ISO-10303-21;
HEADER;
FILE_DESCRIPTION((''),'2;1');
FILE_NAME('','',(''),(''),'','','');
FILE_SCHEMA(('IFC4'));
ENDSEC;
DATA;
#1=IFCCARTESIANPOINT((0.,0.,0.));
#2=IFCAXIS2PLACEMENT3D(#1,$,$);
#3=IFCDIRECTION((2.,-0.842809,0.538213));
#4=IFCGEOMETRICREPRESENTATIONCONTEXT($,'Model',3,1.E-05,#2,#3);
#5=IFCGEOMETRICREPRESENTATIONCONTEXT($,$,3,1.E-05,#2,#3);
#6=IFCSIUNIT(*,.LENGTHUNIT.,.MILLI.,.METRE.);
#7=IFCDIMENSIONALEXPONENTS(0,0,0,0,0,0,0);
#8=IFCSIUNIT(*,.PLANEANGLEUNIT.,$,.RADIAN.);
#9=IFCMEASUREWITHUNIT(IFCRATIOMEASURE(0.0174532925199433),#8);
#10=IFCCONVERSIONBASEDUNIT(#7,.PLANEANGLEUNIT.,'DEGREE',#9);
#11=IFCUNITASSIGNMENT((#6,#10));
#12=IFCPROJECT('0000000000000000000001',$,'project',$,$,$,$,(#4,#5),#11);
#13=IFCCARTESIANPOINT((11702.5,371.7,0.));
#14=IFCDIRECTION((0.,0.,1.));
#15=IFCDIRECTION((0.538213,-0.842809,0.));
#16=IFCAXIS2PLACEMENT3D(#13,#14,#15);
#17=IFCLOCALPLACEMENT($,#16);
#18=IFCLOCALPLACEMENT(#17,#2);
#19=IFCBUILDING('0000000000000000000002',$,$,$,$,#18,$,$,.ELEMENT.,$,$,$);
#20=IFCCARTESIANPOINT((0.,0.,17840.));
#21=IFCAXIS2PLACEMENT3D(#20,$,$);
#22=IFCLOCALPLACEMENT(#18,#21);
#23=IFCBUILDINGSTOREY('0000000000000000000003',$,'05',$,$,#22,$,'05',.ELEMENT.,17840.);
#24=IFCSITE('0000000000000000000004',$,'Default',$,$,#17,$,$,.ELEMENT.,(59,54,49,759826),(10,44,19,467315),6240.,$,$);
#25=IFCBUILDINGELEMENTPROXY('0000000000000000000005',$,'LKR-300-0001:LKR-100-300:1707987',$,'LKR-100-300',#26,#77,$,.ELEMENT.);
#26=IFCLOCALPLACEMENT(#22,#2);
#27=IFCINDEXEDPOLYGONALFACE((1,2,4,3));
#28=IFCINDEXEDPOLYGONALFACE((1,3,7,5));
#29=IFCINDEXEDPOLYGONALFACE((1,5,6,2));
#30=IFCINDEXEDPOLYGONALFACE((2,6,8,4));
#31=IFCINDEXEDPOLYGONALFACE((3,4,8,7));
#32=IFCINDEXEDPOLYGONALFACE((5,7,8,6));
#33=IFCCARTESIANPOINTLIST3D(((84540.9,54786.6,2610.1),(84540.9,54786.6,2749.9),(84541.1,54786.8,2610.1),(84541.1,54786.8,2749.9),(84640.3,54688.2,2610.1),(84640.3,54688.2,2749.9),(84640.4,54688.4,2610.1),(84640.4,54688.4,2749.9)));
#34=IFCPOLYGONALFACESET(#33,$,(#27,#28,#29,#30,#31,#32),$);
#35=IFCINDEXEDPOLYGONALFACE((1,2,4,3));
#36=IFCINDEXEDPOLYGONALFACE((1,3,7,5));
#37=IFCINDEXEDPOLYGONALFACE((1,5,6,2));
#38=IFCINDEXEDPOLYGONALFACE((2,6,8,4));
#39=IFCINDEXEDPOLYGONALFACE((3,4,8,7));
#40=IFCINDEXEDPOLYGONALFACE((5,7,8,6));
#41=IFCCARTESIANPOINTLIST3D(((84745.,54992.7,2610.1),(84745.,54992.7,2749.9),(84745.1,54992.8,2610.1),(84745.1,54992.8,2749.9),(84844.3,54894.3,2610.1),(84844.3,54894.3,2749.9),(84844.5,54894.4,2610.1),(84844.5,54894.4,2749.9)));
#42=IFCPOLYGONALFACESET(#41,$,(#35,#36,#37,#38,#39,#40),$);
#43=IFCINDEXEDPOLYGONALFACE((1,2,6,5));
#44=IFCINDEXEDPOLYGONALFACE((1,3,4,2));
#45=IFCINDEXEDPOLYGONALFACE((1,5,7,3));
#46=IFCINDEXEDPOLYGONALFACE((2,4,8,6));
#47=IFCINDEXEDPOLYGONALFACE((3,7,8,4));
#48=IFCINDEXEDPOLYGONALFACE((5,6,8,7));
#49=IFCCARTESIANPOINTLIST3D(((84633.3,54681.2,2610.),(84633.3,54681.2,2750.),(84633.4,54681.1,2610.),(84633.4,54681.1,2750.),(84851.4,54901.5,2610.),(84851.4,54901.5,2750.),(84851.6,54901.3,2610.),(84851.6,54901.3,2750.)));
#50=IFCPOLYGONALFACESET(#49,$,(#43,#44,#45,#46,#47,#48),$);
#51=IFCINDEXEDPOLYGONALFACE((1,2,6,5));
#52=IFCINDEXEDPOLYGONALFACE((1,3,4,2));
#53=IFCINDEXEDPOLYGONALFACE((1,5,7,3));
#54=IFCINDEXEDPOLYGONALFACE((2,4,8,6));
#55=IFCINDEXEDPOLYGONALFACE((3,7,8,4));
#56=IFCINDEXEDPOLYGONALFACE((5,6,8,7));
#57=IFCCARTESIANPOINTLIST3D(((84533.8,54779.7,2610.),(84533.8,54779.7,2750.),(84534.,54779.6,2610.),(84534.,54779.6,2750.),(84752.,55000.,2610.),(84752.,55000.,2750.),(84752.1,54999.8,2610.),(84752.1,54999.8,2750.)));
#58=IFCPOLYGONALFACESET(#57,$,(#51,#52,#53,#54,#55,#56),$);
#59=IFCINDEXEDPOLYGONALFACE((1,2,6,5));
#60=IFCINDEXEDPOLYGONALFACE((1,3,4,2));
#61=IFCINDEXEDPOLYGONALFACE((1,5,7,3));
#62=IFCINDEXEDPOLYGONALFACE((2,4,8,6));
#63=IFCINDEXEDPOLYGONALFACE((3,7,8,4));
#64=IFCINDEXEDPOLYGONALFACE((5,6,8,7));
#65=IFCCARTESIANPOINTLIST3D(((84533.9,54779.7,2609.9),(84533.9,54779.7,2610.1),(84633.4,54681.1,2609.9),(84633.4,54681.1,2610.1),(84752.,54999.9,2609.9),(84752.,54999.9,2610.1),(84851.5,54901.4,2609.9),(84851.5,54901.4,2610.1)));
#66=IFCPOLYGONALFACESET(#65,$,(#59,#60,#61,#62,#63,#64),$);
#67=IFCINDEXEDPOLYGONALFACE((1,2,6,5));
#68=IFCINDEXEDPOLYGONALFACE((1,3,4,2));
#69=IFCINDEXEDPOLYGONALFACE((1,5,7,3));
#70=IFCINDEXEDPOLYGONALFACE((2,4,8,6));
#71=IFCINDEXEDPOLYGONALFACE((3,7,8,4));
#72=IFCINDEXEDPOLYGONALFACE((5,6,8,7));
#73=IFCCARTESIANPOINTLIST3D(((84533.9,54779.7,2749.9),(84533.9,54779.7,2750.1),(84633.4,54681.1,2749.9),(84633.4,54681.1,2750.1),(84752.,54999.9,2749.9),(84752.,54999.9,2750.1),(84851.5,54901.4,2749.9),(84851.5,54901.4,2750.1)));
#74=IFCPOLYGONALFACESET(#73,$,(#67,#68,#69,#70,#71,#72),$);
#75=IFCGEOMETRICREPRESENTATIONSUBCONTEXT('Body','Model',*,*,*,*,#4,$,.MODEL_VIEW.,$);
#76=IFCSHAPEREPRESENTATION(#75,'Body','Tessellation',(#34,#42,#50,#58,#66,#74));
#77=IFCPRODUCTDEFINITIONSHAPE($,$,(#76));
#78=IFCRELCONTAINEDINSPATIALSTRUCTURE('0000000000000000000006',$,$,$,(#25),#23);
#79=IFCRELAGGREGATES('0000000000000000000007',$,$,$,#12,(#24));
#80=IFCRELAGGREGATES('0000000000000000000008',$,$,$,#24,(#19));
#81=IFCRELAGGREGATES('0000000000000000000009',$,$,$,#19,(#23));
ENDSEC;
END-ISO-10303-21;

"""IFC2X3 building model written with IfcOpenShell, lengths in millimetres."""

from ifc_helpers import new_model, entity, si_unit, converted_unit, direction, frame, frame_2d, origin, origin_2d_with_axis, place, context, subcontext, project, spatial, rectangle, extrude, source, transform, mapped, element, save


model = new_model("IFC2X3")

# Units and contexts
model_context = context("Model", 3, precision=1e-05, world=origin(), true_north=direction((2.0, -0.842809, 0.538213)))
context_of_model = context(None, 3, precision=1e-05, world=origin(), true_north=direction((2.0, -0.842809, 0.538213)))
body_context = subcontext(model_context, "Body", "Model", "MODEL_VIEW")
ifc_project = project(units=[si_unit("LENGTHUNIT", "METRE", prefix="MILLI"), converted_unit("PLANEANGLEUNIT", "DEGREE", entity("IfcRatioMeasure", 0.0174532925199433), si_unit("PLANEANGLEUNIT", "RADIAN"), dimensions=[0, 0, 0, 0, 0, 0, 0])], contexts=[model_context, context_of_model])

# Site, building, storey
site_placement = place(None, frame((11702.5, 371.7, 0.0), z_axis=(0.0, 0.0, 1.0), x_axis=(0.538213, -0.842809, 0.0)))
site = spatial("IfcSite", under=ifc_project, at=site_placement, Name="Default", CompositionType="ELEMENT", RefLatitude=(59, 54, 49, 759826), RefLongitude=(10, 44, 19, 467315), RefElevation=6240.0)
building_placement = place(site_placement, origin())
building = spatial("IfcBuilding", under=site, at=building_placement, CompositionType="ELEMENT")
storey_placement = place(building_placement, frame((0.0, 0.0, 17840.0)))
storey = spatial("IfcBuildingStorey", under=building, at=storey_placement, Name="05", LongName="05", CompositionType="ELEMENT", Elevation=17840.0)

# Building element proxy
shared_shape_1 = source(origin(), body_context, "Body", "SweptSolid", [
    extrude(rectangle(XDim=0.2, YDim=139.8, at=frame_2d((0.0, 0.0), x_axis=(1.0, 0.0))), frame((145.0, 0.0, -69.9)), (0.0, 0.0, 1.0), 139.8),
    extrude(rectangle(XDim=0.2, YDim=139.8, at=frame_2d((0.0, 0.0), x_axis=(1.0, 0.0))), frame((-145.0, 0.0, -69.9)), (0.0, 0.0, 1.0), 139.8),
    extrude(rectangle(XDim=0.2, YDim=310.0, at=frame_2d((0.0, 0.0), x_axis=(1.0, 0.0))), frame((0.0, 70.0, -70.0), z_axis=(0.0, 0.0, 1.0), x_axis=(0.0, 1.0, 0.0)), (0.0, 0.0, 1.0), 140.0),
    extrude(rectangle(XDim=0.2, YDim=310.0, at=frame_2d((0.0, 0.0), x_axis=(1.0, 0.0))), frame((0.0, -70.0, -70.0), z_axis=(0.0, 0.0, 1.0), x_axis=(0.0, 1.0, 0.0)), (0.0, 0.0, 1.0), 140.0),
    extrude(rectangle(XDim=140.0, YDim=310.0, at=origin_2d_with_axis()), frame((0.0, 0.0, -70.1), z_axis=(0.0, 0.0, 1.0), x_axis=(0.0, -1.0, 0.0)), (0.0, 0.0, 1.0), 0.2),
    extrude(rectangle(XDim=140.0, YDim=310.0, at=origin_2d_with_axis()), frame((0.0, 0.0, 69.9), z_axis=(0.0, 0.0, 1.0), x_axis=(0.0, -1.0, 0.0)), (0.0, 0.0, 1.0), 0.2),
])
proxy_1_placement = place(storey_placement, frame((84692.7, 54840.5, 2680.0), z_axis=(0.0, 0.0, 1.0), x_axis=(-0.703669, -0.710528, 0.0)))
element("IfcBuildingElementProxy", 1, at=proxy_1_placement, inside=storey, Name="LKR-300-0001:LKR-100-300:1707987", ObjectType="LKR-100-300", CompositionType="ELEMENT", context=body_context, shape_type="MappedRepresentation", body=[
    mapped(shared_shape_1, transform((0.0, 0.0, 0.0), scale=1.0)),
])

save(model, "model.ifc")
